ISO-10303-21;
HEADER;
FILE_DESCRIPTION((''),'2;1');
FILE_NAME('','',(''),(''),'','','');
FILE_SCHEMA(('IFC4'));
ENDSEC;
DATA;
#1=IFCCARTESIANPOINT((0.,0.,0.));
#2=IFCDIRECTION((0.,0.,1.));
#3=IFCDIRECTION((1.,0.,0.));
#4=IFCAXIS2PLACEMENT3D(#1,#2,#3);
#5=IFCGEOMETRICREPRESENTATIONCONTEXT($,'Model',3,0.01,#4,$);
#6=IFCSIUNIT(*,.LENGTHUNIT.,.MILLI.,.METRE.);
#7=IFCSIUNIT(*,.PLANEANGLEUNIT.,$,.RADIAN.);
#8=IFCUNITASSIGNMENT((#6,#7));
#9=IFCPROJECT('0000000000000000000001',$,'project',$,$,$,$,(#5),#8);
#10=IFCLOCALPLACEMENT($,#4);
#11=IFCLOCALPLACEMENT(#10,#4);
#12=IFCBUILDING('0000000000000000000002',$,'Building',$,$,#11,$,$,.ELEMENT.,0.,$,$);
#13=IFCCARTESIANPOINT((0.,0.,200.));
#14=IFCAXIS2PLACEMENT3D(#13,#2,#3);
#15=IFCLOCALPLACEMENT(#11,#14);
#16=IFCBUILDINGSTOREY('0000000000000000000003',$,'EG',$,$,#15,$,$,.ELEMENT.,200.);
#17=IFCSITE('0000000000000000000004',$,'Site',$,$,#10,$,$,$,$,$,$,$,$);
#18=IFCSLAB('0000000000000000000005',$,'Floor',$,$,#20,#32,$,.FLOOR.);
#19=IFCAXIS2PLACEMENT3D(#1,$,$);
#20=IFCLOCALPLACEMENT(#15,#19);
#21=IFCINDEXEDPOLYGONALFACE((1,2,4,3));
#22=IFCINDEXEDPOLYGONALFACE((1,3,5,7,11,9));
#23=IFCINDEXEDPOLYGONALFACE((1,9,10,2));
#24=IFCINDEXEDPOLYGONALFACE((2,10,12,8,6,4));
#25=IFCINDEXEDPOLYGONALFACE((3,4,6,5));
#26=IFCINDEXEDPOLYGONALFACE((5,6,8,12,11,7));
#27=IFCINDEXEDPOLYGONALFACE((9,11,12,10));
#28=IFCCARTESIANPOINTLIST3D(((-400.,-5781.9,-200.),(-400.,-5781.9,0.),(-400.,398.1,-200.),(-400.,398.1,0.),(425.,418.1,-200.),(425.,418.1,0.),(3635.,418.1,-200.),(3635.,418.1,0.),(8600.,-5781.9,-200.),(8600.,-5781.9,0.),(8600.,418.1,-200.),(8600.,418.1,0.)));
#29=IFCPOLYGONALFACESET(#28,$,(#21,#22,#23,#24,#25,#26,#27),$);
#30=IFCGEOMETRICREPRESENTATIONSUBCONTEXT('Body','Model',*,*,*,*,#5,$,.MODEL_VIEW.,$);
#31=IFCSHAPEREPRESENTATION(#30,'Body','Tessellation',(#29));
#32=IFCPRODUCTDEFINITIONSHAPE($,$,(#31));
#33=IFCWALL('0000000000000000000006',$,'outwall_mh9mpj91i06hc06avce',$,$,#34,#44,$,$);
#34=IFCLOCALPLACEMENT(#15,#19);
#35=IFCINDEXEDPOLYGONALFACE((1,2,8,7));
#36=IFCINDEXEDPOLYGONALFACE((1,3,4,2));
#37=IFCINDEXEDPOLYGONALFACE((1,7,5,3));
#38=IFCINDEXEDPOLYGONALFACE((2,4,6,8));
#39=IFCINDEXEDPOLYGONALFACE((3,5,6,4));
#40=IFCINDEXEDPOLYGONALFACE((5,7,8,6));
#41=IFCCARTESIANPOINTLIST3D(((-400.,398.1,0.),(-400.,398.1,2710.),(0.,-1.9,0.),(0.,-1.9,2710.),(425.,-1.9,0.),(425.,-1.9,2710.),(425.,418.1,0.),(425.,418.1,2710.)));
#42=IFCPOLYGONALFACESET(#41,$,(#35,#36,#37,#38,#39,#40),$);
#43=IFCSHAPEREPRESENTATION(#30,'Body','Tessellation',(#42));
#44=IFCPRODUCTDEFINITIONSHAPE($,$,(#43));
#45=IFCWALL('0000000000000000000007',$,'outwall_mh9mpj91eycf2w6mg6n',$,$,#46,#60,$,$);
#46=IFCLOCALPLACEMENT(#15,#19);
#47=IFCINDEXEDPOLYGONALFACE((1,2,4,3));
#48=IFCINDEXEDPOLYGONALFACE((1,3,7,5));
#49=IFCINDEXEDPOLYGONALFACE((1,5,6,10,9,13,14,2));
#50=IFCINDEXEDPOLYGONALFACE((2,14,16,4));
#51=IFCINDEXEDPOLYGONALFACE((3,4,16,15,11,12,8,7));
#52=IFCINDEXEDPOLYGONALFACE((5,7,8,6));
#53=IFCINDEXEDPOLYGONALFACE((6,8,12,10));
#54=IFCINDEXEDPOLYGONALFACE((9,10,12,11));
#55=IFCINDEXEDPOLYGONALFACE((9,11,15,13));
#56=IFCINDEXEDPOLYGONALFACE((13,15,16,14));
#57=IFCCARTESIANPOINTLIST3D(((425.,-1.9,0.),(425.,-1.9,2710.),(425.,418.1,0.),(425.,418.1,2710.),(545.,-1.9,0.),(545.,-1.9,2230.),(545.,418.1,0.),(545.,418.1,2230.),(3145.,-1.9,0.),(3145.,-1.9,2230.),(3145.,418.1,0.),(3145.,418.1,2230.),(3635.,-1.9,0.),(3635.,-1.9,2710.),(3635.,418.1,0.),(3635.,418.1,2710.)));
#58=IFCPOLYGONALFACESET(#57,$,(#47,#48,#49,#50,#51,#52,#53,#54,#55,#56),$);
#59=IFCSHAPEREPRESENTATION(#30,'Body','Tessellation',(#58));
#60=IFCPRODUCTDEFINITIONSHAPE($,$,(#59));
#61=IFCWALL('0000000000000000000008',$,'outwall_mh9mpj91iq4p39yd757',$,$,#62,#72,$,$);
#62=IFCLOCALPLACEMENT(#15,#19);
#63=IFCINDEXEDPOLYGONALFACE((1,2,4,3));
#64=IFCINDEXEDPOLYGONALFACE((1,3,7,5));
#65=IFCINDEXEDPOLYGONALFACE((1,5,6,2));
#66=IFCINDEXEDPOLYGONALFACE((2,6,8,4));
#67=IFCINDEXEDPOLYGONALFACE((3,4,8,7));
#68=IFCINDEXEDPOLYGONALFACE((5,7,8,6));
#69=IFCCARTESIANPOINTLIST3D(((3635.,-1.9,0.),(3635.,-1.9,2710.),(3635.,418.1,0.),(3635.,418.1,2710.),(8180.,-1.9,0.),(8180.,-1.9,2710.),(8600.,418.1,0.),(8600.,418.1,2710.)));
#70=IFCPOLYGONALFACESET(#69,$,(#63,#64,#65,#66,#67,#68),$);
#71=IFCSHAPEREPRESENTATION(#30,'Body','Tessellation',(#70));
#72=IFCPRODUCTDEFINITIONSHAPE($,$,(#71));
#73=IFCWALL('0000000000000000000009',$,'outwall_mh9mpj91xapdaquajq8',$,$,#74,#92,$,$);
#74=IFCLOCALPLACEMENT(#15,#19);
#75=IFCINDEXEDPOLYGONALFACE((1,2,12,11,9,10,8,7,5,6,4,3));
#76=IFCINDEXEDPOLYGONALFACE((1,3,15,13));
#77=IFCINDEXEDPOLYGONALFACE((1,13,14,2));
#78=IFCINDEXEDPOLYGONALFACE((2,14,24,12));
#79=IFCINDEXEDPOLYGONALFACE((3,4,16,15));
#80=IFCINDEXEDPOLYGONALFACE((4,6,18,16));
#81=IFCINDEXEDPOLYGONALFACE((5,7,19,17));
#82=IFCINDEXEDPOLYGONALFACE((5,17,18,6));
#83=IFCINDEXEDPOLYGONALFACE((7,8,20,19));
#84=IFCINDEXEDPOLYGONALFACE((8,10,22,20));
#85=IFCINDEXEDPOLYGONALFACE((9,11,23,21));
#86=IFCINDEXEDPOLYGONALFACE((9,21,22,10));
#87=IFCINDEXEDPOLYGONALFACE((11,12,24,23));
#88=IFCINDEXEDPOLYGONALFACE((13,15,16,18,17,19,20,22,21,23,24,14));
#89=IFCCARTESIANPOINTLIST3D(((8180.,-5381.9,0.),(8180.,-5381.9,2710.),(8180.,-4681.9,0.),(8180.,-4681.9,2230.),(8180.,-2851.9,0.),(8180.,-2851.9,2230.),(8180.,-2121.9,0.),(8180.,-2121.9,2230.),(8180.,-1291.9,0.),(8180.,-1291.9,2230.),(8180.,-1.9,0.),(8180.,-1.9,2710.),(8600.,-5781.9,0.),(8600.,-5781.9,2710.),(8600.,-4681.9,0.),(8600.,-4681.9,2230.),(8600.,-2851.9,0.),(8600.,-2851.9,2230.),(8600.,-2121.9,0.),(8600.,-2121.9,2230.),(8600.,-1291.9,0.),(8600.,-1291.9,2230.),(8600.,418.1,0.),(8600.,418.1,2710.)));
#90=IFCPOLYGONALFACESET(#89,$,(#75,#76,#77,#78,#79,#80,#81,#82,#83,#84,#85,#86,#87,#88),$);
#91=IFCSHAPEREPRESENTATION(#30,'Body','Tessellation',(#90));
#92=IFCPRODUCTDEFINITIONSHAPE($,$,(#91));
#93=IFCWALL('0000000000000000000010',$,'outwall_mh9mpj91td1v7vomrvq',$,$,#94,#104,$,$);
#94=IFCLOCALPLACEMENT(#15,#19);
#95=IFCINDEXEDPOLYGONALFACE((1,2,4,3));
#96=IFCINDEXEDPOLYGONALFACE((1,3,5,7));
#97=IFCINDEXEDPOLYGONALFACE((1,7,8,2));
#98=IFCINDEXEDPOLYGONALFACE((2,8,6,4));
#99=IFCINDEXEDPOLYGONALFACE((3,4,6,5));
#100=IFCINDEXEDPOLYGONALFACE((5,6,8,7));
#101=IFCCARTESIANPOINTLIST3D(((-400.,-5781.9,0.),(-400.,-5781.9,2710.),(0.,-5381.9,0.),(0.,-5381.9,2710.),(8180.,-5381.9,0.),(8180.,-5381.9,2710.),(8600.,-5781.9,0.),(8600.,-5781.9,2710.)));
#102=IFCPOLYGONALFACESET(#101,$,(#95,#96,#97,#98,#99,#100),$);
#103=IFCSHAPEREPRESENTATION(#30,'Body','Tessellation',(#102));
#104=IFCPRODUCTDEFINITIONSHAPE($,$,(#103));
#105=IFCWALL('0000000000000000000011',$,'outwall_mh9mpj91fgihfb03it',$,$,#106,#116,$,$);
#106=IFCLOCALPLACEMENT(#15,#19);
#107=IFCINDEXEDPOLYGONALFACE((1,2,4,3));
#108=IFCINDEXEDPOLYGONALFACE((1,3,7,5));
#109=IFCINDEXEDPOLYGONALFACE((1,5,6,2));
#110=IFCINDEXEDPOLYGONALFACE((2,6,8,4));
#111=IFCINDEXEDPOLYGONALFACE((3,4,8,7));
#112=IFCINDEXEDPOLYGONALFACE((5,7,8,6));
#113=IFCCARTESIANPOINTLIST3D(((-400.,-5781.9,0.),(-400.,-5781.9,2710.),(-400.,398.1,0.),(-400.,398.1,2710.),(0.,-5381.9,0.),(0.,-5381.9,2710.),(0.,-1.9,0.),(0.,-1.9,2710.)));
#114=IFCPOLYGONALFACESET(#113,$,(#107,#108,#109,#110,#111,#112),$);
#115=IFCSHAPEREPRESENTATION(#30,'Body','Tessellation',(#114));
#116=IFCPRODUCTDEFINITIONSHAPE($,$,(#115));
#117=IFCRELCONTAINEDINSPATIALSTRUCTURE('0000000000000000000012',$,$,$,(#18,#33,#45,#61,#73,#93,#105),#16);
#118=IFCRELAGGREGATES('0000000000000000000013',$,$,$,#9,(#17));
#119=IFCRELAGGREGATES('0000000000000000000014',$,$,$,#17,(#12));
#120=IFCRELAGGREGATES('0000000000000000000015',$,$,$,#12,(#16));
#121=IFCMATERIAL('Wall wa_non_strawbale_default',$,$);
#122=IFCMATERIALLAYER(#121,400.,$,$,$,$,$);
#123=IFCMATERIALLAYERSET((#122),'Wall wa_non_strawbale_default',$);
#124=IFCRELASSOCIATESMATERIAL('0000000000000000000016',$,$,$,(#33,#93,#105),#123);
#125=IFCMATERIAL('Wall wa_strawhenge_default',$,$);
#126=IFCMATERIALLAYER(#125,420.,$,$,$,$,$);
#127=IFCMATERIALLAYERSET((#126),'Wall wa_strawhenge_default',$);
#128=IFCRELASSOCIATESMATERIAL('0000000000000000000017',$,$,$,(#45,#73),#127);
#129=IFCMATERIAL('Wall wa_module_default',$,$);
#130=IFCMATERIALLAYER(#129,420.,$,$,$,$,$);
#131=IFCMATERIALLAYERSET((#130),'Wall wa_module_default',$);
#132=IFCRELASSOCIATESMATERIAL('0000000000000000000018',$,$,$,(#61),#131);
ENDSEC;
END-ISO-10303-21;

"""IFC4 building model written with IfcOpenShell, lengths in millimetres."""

from ifc_helpers import new_model, si_unit, frame, origin_with_axes, place, context, subcontext, project, spatial, polyline, outline, extrude, material, layer, layer_set, layer_usage, element, save


model = new_model("IFC4")

# Units and contexts
model_context = context("Model", 3, precision=0.01, world=origin_with_axes())
body_context = subcontext(model_context, "Body", "Model", "MODEL_VIEW")
ifc_project = project(units=[si_unit("LENGTHUNIT", "METRE", prefix="MILLI"), si_unit("PLANEANGLEUNIT", "RADIAN")], contexts=[model_context])

# Site, building, storey
site_placement = place(None, origin_with_axes())
site = spatial("IfcSite", under=ifc_project, at=site_placement, Name="Site")
building_placement = place(site_placement, origin_with_axes())
building = spatial("IfcBuilding", under=site, at=building_placement, Name="Building", CompositionType="ELEMENT", ElevationOfRefHeight=0.0)
storey_placement = place(building_placement, frame((0.0, 0.0, 200.0), z_axis=(0.0, 0.0, 1.0), x_axis=(1.0, 0.0, 0.0)))
storey = spatial("IfcBuildingStorey", under=building, at=storey_placement, Name="EG", CompositionType="ELEMENT", Elevation=200.0)

# Slab
slab_placement = place(storey_placement, origin_with_axes())
element("IfcSlab", 1, at=slab_placement, inside=storey, Name="Floor", PredefinedType="FLOOR", context=body_context, shape_type="SweptSolid", body=[
    extrude(outline(polyline([(-400.0, -5781.9), (8600.0, -5781.9), (8600.0, 418.1), (3635.0, 418.1), (425.0, 418.1), (-400.0, 398.1), (-400.0, -5781.9)])), origin_with_axes(), (0.0, 0.0, -1.0), 200.0),
])

# Wall
ifc_material_1 = material(Name="Wall wa_non_strawbale_default")
ifc_layer_1 = layer(ifc_material_1, 400.0)
ifc_layer_set_1 = layer_set([ifc_layer_1], Name="Wall wa_non_strawbale_default")
ifc_layer_usage_1 = layer_usage(ifc_layer_set_1, "AXIS2", "POSITIVE", 0.0)
wall_1_placement = place(storey_placement, frame((0.0, -1.9, 0.0), z_axis=(0.0, 0.0, 1.0), x_axis=(1.0, 0.0, 0.0)))
element("IfcWall", 2, at=wall_1_placement, inside=storey, material=ifc_layer_usage_1, Name="outwall_mh9mpj91i06hc06avce", context=body_context, shape_type="SweptSolid", body=[
    extrude(outline(polyline([(0.0, 0.0), (425.0, 0.0), (425.0, 420.0), (-400.0, 400.0), (0.0, 0.0)])), origin_with_axes(), (0.0, 0.0, 1.0), 2710.0),
])

# Wall, opening
ifc_material_2 = material(Name="Wall wa_strawhenge_default")
ifc_layer_2 = layer(ifc_material_2, 420.0)
ifc_layer_set_2 = layer_set([ifc_layer_2], Name="Wall wa_strawhenge_default")
ifc_layer_usage_2 = layer_usage(ifc_layer_set_2, "AXIS2", "POSITIVE", 0.0)
wall_2_placement = place(storey_placement, frame((425.0, -1.9, 0.0), z_axis=(0.0, 0.0, 1.0), x_axis=(1.0, 0.0, 0.0)))
wall_2 = element("IfcWall", 3, at=wall_2_placement, inside=storey, material=ifc_layer_usage_2, Name="outwall_mh9mpj91eycf2w6mg6n", context=body_context, shape_type="SweptSolid", body=[
    extrude(outline(polyline([(0.0, 0.0), (3210.0, 0.0), (3210.0, 420.0), (0.0, 420.0), (0.0, 0.0)])), origin_with_axes(), (0.0, 0.0, 1.0), 2710.0),
])
opening_1_placement = place(wall_2_placement, frame((120.0, 0.0, 0.0), z_axis=(0.0, 0.0, 1.0), x_axis=(1.0, 0.0, 0.0)))
element("IfcOpeningElement", 4, at=opening_1_placement, cuts=wall_2, context=body_context, shape_type="SweptSolid", body=[
    extrude(outline(polyline([(0.0, 0.0), (2600.0, 0.0), (2600.0, 420.0), (0.0, 420.0), (0.0, 0.0)])), origin_with_axes(), (0.0, 0.0, 1.0), 2230.0),
])

# Wall
ifc_material_3 = material(Name="Wall wa_module_default")
ifc_layer_3 = layer(ifc_material_3, 420.0)
ifc_layer_set_3 = layer_set([ifc_layer_3], Name="Wall wa_module_default")
ifc_layer_usage_3 = layer_usage(ifc_layer_set_3, "AXIS2", "POSITIVE", 0.0)
wall_3_placement = place(storey_placement, frame((3635.0, -1.9, 0.0), z_axis=(0.0, 0.0, 1.0), x_axis=(1.0, 0.0, 0.0)))
element("IfcWall", 5, at=wall_3_placement, inside=storey, material=ifc_layer_usage_3, Name="outwall_mh9mpj91iq4p39yd757", context=body_context, shape_type="SweptSolid", body=[
    extrude(outline(polyline([(0.0, 0.0), (4545.0, 0.0), (4965.0, 420.0), (0.0, 420.0), (0.0, 0.0)])), origin_with_axes(), (0.0, 0.0, 1.0), 2710.0),
])

# Wall, openings
wall_4_placement = place(storey_placement, frame((8180.0, -1.9, 0.0), z_axis=(0.0, 0.0, 1.0), x_axis=(0.0, -1.0, 0.0)))
wall_4 = element("IfcWall", 6, at=wall_4_placement, inside=storey, material=ifc_layer_usage_2, Name="outwall_mh9mpj91xapdaquajq8", context=body_context, shape_type="SweptSolid", body=[
    extrude(outline(polyline([(0.0, 0.0), (5380.0, 0.0), (5780.0, 420.0), (-420.0, 420.0), (0.0, 0.0)])), origin_with_axes(), (0.0, 0.0, 1.0), 2710.0),
])
opening_2_placement = place(wall_4_placement, frame((1290.0, 0.0, 0.0), z_axis=(0.0, 0.0, 1.0), x_axis=(1.0, 0.0, 0.0)))
element("IfcOpeningElement", 7, at=opening_2_placement, cuts=wall_4, context=body_context, shape_type="SweptSolid", body=[
    extrude(outline(polyline([(0.0, 0.0), (830.0, 0.0), (830.0, 420.0), (0.0, 420.0), (0.0, 0.0)])), origin_with_axes(), (0.0, 0.0, 1.0), 2230.0),
])
opening_3_placement = place(wall_4_placement, frame((2850.0, 0.0, 0.0), z_axis=(0.0, 0.0, 1.0), x_axis=(1.0, 0.0, 0.0)))
element("IfcOpeningElement", 8, at=opening_3_placement, cuts=wall_4, context=body_context, shape_type="SweptSolid", body=[
    extrude(outline(polyline([(0.0, 0.0), (1830.0, 0.0), (1830.0, 420.0), (0.0, 420.0), (0.0, 0.0)])), origin_with_axes(), (0.0, 0.0, 1.0), 2230.0),
])

# Walls
wall_5_placement = place(storey_placement, frame((8180.0, -5381.9, 0.0), z_axis=(0.0, 0.0, 1.0), x_axis=(-1.0, 0.0, 0.0)))
element("IfcWall", 9, at=wall_5_placement, inside=storey, material=ifc_layer_usage_1, Name="outwall_mh9mpj91td1v7vomrvq", context=body_context, shape_type="SweptSolid", body=[
    extrude(outline(polyline([(0.0, 0.0), (8180.0, 0.0), (8580.0, 400.0), (-420.0, 400.0), (0.0, 0.0)])), origin_with_axes(), (0.0, 0.0, 1.0), 2710.0),
])
wall_6_placement = place(storey_placement, frame((0.0, -5381.9, 0.0), z_axis=(0.0, 0.0, 1.0), x_axis=(0.0, 1.0, 0.0)))
element("IfcWall", 10, at=wall_6_placement, inside=storey, material=ifc_layer_usage_1, Name="outwall_mh9mpj91fgihfb03it", context=body_context, shape_type="SweptSolid", body=[
    extrude(outline(polyline([(0.0, 0.0), (5380.0, 0.0), (5780.0, 400.0), (-400.0, 400.0), (0.0, 0.0)])), origin_with_axes(), (0.0, 0.0, 1.0), 2710.0),
])

save(model, "model.ifc")
